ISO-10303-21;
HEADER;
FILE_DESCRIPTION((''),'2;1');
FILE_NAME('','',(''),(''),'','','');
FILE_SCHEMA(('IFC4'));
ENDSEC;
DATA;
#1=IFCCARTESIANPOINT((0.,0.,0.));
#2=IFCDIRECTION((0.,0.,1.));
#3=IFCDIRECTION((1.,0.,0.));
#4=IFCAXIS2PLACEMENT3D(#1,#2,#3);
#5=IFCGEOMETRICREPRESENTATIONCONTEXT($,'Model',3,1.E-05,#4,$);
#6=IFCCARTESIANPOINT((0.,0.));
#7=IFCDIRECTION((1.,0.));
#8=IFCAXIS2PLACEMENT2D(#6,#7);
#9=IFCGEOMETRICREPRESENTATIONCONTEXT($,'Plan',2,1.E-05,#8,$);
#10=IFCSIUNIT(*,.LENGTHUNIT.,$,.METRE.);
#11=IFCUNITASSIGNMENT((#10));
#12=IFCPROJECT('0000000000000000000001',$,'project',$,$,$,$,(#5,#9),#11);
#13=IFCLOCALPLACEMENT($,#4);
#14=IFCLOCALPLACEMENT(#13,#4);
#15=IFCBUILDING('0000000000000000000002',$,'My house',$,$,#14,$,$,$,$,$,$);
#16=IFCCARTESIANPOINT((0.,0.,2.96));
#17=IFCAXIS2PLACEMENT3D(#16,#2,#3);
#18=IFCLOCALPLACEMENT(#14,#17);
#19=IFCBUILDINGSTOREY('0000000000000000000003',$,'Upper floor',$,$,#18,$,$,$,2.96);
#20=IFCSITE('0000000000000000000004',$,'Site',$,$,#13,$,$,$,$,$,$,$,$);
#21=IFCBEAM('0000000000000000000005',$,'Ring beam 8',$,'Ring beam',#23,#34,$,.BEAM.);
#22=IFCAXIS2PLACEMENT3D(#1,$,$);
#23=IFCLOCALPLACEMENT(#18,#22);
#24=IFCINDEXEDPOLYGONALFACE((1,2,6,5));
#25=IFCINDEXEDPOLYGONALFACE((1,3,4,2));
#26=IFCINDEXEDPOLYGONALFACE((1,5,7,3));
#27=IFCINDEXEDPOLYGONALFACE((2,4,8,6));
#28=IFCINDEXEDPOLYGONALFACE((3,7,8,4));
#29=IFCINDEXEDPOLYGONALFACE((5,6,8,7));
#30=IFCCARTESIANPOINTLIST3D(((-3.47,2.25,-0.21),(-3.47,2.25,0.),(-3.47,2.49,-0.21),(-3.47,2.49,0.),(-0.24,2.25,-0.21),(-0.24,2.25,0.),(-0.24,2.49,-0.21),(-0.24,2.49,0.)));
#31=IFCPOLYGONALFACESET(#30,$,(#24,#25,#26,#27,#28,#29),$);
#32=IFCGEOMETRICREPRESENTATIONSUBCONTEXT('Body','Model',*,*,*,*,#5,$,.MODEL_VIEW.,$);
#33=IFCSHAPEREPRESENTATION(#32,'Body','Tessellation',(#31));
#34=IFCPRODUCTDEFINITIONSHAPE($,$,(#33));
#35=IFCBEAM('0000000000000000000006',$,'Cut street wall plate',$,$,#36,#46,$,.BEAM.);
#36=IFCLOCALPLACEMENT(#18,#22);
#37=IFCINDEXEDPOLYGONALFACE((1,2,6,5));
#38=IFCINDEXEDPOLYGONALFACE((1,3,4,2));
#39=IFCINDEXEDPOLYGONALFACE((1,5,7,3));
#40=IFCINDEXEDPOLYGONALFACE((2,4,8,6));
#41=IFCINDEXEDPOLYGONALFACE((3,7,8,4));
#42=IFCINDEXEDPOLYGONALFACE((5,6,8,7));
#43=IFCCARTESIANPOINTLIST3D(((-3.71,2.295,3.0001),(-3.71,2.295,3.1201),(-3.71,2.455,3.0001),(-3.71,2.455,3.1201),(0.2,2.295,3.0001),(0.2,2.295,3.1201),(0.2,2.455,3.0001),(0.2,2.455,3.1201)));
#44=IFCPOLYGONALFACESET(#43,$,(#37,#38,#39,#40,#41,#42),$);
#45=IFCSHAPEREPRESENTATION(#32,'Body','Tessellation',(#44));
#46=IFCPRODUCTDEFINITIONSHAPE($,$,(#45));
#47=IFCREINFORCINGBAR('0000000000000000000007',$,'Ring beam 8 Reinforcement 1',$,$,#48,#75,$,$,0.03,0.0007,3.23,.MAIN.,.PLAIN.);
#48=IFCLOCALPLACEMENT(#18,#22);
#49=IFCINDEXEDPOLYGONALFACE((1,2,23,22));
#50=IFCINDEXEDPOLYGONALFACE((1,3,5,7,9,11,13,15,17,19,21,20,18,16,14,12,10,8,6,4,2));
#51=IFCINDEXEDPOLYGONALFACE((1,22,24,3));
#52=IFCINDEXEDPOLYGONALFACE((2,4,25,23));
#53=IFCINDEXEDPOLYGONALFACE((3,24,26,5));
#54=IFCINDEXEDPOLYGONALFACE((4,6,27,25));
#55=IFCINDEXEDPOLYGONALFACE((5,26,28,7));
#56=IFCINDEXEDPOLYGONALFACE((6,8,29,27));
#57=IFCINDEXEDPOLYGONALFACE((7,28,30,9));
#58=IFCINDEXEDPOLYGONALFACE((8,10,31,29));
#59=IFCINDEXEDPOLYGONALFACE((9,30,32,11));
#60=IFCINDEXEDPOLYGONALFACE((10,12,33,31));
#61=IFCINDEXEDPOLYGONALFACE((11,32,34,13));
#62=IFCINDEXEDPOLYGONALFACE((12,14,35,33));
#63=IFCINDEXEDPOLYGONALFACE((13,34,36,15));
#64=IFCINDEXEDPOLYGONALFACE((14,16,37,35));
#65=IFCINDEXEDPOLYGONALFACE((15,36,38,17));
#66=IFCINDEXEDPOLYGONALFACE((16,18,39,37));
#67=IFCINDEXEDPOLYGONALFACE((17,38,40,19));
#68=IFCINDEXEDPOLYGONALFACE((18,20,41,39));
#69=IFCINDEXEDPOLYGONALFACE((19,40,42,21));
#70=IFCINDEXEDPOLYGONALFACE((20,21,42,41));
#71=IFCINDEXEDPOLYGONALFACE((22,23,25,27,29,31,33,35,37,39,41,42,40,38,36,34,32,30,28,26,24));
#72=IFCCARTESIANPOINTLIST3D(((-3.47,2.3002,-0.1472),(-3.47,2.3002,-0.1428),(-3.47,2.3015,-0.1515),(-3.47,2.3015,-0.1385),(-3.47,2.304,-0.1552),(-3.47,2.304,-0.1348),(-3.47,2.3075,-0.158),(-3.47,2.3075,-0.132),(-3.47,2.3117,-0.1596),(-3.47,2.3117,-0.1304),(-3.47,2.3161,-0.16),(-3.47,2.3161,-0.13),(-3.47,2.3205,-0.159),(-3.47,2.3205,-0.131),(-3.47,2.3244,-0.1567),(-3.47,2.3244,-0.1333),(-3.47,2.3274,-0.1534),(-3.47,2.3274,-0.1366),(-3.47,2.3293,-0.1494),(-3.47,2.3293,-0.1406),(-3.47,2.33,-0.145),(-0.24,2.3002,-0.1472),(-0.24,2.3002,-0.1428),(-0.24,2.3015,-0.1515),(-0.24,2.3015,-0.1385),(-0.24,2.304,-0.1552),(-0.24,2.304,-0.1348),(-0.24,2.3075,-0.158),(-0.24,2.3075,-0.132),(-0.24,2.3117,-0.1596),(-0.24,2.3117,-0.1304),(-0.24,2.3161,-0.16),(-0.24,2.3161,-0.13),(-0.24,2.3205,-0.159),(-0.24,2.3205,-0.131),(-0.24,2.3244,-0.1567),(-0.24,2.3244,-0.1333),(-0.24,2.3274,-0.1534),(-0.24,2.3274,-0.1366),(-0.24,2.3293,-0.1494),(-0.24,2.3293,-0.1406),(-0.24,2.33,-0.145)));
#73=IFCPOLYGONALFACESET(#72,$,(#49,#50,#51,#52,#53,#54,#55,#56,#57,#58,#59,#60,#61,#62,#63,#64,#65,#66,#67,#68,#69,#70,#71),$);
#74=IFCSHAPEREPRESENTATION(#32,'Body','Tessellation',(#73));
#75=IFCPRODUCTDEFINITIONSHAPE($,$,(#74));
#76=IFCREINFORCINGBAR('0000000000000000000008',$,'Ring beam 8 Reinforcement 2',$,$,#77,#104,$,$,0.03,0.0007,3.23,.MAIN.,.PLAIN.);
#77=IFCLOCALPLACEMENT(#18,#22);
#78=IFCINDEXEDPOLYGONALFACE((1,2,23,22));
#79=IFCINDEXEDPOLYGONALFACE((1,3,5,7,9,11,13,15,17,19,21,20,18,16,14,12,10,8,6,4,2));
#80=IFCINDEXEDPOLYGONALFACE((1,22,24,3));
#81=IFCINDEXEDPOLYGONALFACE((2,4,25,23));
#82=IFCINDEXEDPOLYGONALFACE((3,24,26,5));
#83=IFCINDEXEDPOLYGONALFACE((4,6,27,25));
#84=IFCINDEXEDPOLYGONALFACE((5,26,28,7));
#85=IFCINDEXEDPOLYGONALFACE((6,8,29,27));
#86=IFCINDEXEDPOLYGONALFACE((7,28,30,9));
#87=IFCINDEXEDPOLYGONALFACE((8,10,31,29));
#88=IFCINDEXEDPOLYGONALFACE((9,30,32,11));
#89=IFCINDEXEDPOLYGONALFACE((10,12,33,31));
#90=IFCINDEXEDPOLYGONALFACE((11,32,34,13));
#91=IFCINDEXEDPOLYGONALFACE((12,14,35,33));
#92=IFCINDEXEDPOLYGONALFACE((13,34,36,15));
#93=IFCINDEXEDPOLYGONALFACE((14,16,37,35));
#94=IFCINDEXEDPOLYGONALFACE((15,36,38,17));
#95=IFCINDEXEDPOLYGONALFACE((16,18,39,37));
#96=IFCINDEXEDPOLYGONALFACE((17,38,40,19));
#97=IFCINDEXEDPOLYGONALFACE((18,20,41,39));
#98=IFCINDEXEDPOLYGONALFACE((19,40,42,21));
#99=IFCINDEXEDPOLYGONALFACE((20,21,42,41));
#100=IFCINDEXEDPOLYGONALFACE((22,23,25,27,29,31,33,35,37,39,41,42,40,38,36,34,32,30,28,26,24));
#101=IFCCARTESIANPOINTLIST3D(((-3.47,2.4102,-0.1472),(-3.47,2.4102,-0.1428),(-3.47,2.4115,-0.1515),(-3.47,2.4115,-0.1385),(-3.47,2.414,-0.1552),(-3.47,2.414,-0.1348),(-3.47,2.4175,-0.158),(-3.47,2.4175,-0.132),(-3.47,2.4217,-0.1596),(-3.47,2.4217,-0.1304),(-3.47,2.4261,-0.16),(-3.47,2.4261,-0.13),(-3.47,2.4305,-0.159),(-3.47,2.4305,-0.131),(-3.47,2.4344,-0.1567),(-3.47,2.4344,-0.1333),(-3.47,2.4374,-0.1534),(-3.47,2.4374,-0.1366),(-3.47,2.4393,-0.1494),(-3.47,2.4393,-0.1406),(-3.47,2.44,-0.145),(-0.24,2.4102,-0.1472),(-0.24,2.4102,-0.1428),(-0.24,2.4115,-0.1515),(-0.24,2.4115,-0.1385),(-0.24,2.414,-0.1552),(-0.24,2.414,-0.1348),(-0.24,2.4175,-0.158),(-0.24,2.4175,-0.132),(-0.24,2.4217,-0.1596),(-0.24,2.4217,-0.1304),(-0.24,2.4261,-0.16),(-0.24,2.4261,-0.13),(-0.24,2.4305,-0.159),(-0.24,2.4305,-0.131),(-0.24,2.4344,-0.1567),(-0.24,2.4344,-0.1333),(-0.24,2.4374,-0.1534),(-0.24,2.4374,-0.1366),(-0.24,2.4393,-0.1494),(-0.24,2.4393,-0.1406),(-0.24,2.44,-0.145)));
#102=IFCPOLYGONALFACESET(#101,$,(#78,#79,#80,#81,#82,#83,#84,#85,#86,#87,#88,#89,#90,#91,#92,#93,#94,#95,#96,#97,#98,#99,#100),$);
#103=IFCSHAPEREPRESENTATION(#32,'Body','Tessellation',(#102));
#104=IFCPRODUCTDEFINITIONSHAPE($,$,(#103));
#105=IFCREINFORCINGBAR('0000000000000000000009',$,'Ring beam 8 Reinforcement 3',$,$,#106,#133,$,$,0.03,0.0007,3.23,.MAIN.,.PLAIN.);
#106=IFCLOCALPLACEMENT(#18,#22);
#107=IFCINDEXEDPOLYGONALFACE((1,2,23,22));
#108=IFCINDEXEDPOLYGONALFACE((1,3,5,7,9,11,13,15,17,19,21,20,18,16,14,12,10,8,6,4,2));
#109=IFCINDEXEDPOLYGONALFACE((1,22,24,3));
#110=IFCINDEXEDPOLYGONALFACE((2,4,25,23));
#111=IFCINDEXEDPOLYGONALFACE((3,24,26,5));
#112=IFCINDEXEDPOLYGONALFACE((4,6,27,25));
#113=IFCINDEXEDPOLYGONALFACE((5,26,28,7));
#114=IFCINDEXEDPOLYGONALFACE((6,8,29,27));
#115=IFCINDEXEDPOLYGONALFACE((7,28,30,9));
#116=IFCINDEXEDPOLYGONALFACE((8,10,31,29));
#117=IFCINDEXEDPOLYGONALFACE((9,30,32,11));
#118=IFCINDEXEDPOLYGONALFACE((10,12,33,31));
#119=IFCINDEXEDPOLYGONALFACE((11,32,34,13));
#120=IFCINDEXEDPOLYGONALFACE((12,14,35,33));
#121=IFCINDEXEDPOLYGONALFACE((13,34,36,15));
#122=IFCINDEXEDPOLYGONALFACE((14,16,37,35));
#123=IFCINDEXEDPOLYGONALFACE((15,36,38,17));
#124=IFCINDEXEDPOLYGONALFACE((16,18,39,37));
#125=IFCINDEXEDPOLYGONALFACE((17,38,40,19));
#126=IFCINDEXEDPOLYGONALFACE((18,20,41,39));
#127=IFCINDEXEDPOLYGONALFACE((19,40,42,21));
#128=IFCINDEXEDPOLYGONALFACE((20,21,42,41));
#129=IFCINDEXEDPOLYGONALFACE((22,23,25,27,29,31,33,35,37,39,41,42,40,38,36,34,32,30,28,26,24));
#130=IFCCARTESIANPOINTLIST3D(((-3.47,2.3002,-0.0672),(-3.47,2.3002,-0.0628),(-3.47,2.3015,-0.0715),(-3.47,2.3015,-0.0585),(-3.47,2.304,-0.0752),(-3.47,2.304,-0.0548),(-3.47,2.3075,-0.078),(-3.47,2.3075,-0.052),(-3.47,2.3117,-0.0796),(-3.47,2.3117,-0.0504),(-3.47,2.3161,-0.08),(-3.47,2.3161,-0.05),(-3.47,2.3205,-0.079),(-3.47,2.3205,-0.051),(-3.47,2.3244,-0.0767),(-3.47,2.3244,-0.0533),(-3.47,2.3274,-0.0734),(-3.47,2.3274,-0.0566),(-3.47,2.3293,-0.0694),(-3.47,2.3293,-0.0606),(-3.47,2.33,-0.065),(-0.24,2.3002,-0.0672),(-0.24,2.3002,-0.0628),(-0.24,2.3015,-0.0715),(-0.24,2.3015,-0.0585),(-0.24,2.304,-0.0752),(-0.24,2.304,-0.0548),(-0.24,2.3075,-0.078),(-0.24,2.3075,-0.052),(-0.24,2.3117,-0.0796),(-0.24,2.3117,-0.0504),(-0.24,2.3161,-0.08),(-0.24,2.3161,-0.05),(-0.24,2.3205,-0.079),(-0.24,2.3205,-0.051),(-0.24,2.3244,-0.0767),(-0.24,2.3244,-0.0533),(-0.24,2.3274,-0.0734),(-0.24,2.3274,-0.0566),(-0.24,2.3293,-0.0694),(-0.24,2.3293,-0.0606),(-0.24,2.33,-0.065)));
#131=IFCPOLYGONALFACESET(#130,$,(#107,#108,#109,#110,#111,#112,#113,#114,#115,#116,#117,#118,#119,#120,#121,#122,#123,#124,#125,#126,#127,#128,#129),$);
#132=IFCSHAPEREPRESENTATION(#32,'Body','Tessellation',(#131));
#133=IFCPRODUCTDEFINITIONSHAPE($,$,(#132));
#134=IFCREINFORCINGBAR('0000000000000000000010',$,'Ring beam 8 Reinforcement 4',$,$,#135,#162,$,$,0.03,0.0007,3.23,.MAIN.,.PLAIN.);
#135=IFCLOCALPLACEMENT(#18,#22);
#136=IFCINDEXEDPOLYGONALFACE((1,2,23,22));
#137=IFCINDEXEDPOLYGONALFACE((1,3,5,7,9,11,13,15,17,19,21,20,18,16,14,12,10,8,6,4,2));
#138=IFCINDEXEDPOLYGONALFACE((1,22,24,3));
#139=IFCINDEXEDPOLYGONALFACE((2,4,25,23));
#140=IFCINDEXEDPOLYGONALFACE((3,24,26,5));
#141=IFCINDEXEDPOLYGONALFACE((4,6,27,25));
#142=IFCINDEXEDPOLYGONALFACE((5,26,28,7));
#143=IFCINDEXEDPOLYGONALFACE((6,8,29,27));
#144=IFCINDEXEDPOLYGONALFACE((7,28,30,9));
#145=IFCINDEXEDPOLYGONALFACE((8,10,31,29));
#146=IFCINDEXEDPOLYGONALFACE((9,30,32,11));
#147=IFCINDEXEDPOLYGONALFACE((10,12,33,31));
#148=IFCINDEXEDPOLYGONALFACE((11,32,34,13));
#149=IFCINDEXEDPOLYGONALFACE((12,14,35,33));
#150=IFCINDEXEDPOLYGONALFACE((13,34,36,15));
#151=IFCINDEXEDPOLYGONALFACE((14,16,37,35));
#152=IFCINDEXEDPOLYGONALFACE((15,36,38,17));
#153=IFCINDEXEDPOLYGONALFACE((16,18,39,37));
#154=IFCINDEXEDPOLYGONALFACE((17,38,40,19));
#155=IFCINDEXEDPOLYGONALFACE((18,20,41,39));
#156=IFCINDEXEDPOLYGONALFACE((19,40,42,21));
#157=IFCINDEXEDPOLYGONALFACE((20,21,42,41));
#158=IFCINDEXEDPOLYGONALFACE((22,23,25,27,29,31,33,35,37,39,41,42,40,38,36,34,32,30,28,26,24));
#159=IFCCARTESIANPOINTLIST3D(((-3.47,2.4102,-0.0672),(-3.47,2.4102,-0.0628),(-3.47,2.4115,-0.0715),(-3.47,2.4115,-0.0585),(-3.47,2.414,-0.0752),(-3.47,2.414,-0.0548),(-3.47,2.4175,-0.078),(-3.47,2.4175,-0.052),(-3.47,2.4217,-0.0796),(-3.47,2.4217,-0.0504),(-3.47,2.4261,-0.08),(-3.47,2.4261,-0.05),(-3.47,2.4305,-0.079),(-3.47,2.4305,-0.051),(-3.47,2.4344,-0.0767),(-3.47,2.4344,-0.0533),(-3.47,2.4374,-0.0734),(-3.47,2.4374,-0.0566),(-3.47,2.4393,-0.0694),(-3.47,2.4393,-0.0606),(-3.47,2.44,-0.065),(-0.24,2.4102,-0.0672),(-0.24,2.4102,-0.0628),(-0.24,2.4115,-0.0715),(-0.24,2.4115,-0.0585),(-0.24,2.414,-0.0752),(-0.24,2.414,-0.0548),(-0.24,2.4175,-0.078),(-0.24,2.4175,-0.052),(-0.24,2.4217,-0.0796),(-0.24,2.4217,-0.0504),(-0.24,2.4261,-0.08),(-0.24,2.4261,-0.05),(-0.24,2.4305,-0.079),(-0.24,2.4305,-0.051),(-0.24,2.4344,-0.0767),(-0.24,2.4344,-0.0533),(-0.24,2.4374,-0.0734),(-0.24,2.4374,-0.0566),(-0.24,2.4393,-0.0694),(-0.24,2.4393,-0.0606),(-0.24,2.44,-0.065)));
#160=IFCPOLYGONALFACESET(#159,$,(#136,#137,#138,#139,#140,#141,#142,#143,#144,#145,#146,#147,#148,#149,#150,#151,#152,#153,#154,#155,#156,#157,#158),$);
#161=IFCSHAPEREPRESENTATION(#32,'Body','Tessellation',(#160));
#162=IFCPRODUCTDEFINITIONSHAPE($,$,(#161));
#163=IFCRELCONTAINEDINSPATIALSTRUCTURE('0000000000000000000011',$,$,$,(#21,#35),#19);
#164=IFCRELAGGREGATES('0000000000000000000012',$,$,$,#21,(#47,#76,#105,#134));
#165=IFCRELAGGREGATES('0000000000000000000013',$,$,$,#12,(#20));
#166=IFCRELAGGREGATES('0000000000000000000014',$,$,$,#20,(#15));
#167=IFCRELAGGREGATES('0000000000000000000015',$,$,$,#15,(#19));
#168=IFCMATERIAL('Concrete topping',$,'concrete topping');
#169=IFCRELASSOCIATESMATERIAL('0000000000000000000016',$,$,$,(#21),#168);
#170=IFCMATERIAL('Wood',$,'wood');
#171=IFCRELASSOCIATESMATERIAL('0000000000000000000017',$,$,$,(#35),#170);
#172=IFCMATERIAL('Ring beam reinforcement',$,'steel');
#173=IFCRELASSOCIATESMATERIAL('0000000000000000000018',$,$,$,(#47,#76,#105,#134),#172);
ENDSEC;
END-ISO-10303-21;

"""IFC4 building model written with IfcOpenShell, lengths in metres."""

from ifc_helpers import new_model, si_unit, frame, origin_with_axes, origin_2d, origin_2d_with_axis, place, context, subcontext, project, spatial, circle_curve, rectangle, outline, extrude, source, transform, mapped, material, element, aggregate, save


model = new_model("IFC4")

# Units and contexts
model_context = context("Model", 3, precision=1e-05, world=origin_with_axes())
plan_context = context("Plan", 2, precision=1e-05, world=origin_2d_with_axis())
body_context_1 = subcontext(model_context, "Body", "Model", "MODEL_VIEW")
ifc_project = project(units=[si_unit("LENGTHUNIT", "METRE")], contexts=[model_context, plan_context])

# Site, building, storey
site_placement = place(None, origin_with_axes())
site = spatial("IfcSite", under=ifc_project, at=site_placement, Name="Site")
building_placement = place(site_placement, origin_with_axes())
building = spatial("IfcBuilding", under=site, at=building_placement, Name="My house")
storey_placement = place(building_placement, frame((0.0, 0.0, 2.96), z_axis=(0.0, 0.0, 1.0), x_axis=(1.0, 0.0, 0.0)))
storey = spatial("IfcBuildingStorey", under=building, at=storey_placement, Name="Upper floor", Elevation=2.96)

# Beams
ifc_material_1 = material(Name="Concrete topping", Category="concrete topping")
shared_shape_1 = source(origin_with_axes(), body_context_1, "Body", "SweptSolid", [
    extrude(rectangle(XDim=0.24, YDim=0.21), frame((0.0, 0.0, 0.0), z_axis=(1.0, 0.0, 0.0), x_axis=(0.0, 1.0, 0.0)), (0.0, 0.0, 1.0), 3.23),
])
beam_1_placement = place(storey_placement, frame((-0.24, 2.37, -0.105), z_axis=(0.0, 0.0, 1.0), x_axis=(1.0, 0.0, 0.0)))
beam_1 = element("IfcBeam", 1, at=beam_1_placement, inside=storey, material=ifc_material_1, Name="Ring beam 8", ObjectType="Ring beam", PredefinedType="BEAM", context=body_context_1, shape_type="MappedRepresentation", body=[
    mapped(shared_shape_1, transform((0.0, 0.0, 0.0), x_axis=(-1.0, 0.0, 0.0), y_axis=(0.0, 1.0, 0.0), z_axis=(0.0, 0.0, 1.0), scale=1.0)),
])
ifc_material_2 = material(Name="Wood", Category="wood")
shared_shape_2 = source(origin_with_axes(), body_context_1, "Body", "SweptSolid", [
    extrude(rectangle(XDim=0.16, YDim=0.12), frame((0.0, 0.0, 0.0), z_axis=(1.0, 0.0, 0.0), x_axis=(0.0, 1.0, 0.0)), (0.0, 0.0, 1.0), 3.91),
])
beam_2_placement = place(storey_placement, frame((0.2, 2.375, 3.0601), z_axis=(0.0, 0.0, 1.0), x_axis=(1.0, 0.0, 0.0)))
element("IfcBeam", 2, at=beam_2_placement, inside=storey, material=ifc_material_2, Name="Cut street wall plate", PredefinedType="BEAM", context=body_context_1, shape_type="MappedRepresentation", body=[
    mapped(shared_shape_2, transform((0.0, 0.0, 0.0), x_axis=(-1.0, 0.0, 0.0), y_axis=(0.0, 1.0, 0.0), z_axis=(0.0, 0.0, 1.0), scale=1.0)),
])

# Reinforcing bars
ifc_material_3 = material(Name="Ring beam reinforcement", Category="steel")
shared_shape_3 = source(origin_with_axes(), body_context_1, "Body", "SweptSolid", [
    extrude(outline(circle_curve(origin_2d(), 0.015)), frame((0.0, 0.0, 0.0), z_axis=(1.0, 0.0, 0.0), x_axis=(0.0, 1.0, 0.0)), (0.0, 0.0, 1.0), 3.23),
])
reinforcing_bar_1_placement = place(beam_1_placement, frame((0.0, -0.055, -0.04), z_axis=(0.0, 0.0, 1.0), x_axis=(1.0, 0.0, 0.0)))
reinforcing_bar_1 = element("IfcReinforcingBar", 3, at=reinforcing_bar_1_placement, material=ifc_material_3, Name="Ring beam 8 Reinforcement 1", BarLength=3.23, BarSurface="PLAIN", CrossSectionArea=0.0007, NominalDiameter=0.03, PredefinedType="MAIN", context=body_context_1, shape_type="MappedRepresentation", body=[
    mapped(shared_shape_3, transform((0.0, 0.0, 0.0), x_axis=(-1.0, 0.0, 0.0), y_axis=(0.0, 1.0, 0.0), z_axis=(0.0, 0.0, 1.0), scale=1.0)),
])
shared_shape_4 = source(origin_with_axes(), body_context_1, "Body", "SweptSolid", [
    extrude(outline(circle_curve(origin_2d(), 0.015)), frame((0.0, 0.0, 0.0), z_axis=(1.0, 0.0, 0.0), x_axis=(0.0, 1.0, 0.0)), (0.0, 0.0, 1.0), 3.23),
])
reinforcing_bar_2_placement = place(beam_1_placement, frame((0.0, 0.055, -0.04), z_axis=(0.0, 0.0, 1.0), x_axis=(1.0, 0.0, 0.0)))
reinforcing_bar_2 = element("IfcReinforcingBar", 4, at=reinforcing_bar_2_placement, material=ifc_material_3, Name="Ring beam 8 Reinforcement 2", BarLength=3.23, BarSurface="PLAIN", CrossSectionArea=0.0007, NominalDiameter=0.03, PredefinedType="MAIN", context=body_context_1, shape_type="MappedRepresentation", body=[
    mapped(shared_shape_4, transform((0.0, 0.0, 0.0), x_axis=(-1.0, 0.0, 0.0), y_axis=(0.0, 1.0, 0.0), z_axis=(0.0, 0.0, 1.0), scale=1.0)),
])
shared_shape_5 = source(origin_with_axes(), body_context_1, "Body", "SweptSolid", [
    extrude(outline(circle_curve(origin_2d(), 0.015)), frame((0.0, 0.0, 0.0), z_axis=(1.0, 0.0, 0.0), x_axis=(0.0, 1.0, 0.0)), (0.0, 0.0, 1.0), 3.23),
])
reinforcing_bar_3_placement = place(beam_1_placement, frame((0.0, -0.055, 0.04), z_axis=(0.0, 0.0, 1.0), x_axis=(1.0, 0.0, 0.0)))
reinforcing_bar_3 = element("IfcReinforcingBar", 5, at=reinforcing_bar_3_placement, material=ifc_material_3, Name="Ring beam 8 Reinforcement 3", BarLength=3.23, BarSurface="PLAIN", CrossSectionArea=0.0007, NominalDiameter=0.03, PredefinedType="MAIN", context=body_context_1, shape_type="MappedRepresentation", body=[
    mapped(shared_shape_5, transform((0.0, 0.0, 0.0), x_axis=(-1.0, 0.0, 0.0), y_axis=(0.0, 1.0, 0.0), z_axis=(0.0, 0.0, 1.0), scale=1.0)),
])
shared_shape_6 = source(origin_with_axes(), body_context_1, "Body", "SweptSolid", [
    extrude(outline(circle_curve(origin_2d(), 0.015)), frame((0.0, 0.0, 0.0), z_axis=(1.0, 0.0, 0.0), x_axis=(0.0, 1.0, 0.0)), (0.0, 0.0, 1.0), 3.23),
])
reinforcing_bar_4_placement = place(beam_1_placement, frame((0.0, 0.055, 0.04), z_axis=(0.0, 0.0, 1.0), x_axis=(1.0, 0.0, 0.0)))
reinforcing_bar_4 = element("IfcReinforcingBar", 6, at=reinforcing_bar_4_placement, material=ifc_material_3, Name="Ring beam 8 Reinforcement 4", BarLength=3.23, BarSurface="PLAIN", CrossSectionArea=0.0007, NominalDiameter=0.03, PredefinedType="MAIN", context=body_context_1, shape_type="MappedRepresentation", body=[
    mapped(shared_shape_6, transform((0.0, 0.0, 0.0), x_axis=(-1.0, 0.0, 0.0), y_axis=(0.0, 1.0, 0.0), z_axis=(0.0, 0.0, 1.0), scale=1.0)),
])
aggregate(beam_1, [reinforcing_bar_1, reinforcing_bar_2, reinforcing_bar_3, reinforcing_bar_4])

save(model, "model.ifc")
